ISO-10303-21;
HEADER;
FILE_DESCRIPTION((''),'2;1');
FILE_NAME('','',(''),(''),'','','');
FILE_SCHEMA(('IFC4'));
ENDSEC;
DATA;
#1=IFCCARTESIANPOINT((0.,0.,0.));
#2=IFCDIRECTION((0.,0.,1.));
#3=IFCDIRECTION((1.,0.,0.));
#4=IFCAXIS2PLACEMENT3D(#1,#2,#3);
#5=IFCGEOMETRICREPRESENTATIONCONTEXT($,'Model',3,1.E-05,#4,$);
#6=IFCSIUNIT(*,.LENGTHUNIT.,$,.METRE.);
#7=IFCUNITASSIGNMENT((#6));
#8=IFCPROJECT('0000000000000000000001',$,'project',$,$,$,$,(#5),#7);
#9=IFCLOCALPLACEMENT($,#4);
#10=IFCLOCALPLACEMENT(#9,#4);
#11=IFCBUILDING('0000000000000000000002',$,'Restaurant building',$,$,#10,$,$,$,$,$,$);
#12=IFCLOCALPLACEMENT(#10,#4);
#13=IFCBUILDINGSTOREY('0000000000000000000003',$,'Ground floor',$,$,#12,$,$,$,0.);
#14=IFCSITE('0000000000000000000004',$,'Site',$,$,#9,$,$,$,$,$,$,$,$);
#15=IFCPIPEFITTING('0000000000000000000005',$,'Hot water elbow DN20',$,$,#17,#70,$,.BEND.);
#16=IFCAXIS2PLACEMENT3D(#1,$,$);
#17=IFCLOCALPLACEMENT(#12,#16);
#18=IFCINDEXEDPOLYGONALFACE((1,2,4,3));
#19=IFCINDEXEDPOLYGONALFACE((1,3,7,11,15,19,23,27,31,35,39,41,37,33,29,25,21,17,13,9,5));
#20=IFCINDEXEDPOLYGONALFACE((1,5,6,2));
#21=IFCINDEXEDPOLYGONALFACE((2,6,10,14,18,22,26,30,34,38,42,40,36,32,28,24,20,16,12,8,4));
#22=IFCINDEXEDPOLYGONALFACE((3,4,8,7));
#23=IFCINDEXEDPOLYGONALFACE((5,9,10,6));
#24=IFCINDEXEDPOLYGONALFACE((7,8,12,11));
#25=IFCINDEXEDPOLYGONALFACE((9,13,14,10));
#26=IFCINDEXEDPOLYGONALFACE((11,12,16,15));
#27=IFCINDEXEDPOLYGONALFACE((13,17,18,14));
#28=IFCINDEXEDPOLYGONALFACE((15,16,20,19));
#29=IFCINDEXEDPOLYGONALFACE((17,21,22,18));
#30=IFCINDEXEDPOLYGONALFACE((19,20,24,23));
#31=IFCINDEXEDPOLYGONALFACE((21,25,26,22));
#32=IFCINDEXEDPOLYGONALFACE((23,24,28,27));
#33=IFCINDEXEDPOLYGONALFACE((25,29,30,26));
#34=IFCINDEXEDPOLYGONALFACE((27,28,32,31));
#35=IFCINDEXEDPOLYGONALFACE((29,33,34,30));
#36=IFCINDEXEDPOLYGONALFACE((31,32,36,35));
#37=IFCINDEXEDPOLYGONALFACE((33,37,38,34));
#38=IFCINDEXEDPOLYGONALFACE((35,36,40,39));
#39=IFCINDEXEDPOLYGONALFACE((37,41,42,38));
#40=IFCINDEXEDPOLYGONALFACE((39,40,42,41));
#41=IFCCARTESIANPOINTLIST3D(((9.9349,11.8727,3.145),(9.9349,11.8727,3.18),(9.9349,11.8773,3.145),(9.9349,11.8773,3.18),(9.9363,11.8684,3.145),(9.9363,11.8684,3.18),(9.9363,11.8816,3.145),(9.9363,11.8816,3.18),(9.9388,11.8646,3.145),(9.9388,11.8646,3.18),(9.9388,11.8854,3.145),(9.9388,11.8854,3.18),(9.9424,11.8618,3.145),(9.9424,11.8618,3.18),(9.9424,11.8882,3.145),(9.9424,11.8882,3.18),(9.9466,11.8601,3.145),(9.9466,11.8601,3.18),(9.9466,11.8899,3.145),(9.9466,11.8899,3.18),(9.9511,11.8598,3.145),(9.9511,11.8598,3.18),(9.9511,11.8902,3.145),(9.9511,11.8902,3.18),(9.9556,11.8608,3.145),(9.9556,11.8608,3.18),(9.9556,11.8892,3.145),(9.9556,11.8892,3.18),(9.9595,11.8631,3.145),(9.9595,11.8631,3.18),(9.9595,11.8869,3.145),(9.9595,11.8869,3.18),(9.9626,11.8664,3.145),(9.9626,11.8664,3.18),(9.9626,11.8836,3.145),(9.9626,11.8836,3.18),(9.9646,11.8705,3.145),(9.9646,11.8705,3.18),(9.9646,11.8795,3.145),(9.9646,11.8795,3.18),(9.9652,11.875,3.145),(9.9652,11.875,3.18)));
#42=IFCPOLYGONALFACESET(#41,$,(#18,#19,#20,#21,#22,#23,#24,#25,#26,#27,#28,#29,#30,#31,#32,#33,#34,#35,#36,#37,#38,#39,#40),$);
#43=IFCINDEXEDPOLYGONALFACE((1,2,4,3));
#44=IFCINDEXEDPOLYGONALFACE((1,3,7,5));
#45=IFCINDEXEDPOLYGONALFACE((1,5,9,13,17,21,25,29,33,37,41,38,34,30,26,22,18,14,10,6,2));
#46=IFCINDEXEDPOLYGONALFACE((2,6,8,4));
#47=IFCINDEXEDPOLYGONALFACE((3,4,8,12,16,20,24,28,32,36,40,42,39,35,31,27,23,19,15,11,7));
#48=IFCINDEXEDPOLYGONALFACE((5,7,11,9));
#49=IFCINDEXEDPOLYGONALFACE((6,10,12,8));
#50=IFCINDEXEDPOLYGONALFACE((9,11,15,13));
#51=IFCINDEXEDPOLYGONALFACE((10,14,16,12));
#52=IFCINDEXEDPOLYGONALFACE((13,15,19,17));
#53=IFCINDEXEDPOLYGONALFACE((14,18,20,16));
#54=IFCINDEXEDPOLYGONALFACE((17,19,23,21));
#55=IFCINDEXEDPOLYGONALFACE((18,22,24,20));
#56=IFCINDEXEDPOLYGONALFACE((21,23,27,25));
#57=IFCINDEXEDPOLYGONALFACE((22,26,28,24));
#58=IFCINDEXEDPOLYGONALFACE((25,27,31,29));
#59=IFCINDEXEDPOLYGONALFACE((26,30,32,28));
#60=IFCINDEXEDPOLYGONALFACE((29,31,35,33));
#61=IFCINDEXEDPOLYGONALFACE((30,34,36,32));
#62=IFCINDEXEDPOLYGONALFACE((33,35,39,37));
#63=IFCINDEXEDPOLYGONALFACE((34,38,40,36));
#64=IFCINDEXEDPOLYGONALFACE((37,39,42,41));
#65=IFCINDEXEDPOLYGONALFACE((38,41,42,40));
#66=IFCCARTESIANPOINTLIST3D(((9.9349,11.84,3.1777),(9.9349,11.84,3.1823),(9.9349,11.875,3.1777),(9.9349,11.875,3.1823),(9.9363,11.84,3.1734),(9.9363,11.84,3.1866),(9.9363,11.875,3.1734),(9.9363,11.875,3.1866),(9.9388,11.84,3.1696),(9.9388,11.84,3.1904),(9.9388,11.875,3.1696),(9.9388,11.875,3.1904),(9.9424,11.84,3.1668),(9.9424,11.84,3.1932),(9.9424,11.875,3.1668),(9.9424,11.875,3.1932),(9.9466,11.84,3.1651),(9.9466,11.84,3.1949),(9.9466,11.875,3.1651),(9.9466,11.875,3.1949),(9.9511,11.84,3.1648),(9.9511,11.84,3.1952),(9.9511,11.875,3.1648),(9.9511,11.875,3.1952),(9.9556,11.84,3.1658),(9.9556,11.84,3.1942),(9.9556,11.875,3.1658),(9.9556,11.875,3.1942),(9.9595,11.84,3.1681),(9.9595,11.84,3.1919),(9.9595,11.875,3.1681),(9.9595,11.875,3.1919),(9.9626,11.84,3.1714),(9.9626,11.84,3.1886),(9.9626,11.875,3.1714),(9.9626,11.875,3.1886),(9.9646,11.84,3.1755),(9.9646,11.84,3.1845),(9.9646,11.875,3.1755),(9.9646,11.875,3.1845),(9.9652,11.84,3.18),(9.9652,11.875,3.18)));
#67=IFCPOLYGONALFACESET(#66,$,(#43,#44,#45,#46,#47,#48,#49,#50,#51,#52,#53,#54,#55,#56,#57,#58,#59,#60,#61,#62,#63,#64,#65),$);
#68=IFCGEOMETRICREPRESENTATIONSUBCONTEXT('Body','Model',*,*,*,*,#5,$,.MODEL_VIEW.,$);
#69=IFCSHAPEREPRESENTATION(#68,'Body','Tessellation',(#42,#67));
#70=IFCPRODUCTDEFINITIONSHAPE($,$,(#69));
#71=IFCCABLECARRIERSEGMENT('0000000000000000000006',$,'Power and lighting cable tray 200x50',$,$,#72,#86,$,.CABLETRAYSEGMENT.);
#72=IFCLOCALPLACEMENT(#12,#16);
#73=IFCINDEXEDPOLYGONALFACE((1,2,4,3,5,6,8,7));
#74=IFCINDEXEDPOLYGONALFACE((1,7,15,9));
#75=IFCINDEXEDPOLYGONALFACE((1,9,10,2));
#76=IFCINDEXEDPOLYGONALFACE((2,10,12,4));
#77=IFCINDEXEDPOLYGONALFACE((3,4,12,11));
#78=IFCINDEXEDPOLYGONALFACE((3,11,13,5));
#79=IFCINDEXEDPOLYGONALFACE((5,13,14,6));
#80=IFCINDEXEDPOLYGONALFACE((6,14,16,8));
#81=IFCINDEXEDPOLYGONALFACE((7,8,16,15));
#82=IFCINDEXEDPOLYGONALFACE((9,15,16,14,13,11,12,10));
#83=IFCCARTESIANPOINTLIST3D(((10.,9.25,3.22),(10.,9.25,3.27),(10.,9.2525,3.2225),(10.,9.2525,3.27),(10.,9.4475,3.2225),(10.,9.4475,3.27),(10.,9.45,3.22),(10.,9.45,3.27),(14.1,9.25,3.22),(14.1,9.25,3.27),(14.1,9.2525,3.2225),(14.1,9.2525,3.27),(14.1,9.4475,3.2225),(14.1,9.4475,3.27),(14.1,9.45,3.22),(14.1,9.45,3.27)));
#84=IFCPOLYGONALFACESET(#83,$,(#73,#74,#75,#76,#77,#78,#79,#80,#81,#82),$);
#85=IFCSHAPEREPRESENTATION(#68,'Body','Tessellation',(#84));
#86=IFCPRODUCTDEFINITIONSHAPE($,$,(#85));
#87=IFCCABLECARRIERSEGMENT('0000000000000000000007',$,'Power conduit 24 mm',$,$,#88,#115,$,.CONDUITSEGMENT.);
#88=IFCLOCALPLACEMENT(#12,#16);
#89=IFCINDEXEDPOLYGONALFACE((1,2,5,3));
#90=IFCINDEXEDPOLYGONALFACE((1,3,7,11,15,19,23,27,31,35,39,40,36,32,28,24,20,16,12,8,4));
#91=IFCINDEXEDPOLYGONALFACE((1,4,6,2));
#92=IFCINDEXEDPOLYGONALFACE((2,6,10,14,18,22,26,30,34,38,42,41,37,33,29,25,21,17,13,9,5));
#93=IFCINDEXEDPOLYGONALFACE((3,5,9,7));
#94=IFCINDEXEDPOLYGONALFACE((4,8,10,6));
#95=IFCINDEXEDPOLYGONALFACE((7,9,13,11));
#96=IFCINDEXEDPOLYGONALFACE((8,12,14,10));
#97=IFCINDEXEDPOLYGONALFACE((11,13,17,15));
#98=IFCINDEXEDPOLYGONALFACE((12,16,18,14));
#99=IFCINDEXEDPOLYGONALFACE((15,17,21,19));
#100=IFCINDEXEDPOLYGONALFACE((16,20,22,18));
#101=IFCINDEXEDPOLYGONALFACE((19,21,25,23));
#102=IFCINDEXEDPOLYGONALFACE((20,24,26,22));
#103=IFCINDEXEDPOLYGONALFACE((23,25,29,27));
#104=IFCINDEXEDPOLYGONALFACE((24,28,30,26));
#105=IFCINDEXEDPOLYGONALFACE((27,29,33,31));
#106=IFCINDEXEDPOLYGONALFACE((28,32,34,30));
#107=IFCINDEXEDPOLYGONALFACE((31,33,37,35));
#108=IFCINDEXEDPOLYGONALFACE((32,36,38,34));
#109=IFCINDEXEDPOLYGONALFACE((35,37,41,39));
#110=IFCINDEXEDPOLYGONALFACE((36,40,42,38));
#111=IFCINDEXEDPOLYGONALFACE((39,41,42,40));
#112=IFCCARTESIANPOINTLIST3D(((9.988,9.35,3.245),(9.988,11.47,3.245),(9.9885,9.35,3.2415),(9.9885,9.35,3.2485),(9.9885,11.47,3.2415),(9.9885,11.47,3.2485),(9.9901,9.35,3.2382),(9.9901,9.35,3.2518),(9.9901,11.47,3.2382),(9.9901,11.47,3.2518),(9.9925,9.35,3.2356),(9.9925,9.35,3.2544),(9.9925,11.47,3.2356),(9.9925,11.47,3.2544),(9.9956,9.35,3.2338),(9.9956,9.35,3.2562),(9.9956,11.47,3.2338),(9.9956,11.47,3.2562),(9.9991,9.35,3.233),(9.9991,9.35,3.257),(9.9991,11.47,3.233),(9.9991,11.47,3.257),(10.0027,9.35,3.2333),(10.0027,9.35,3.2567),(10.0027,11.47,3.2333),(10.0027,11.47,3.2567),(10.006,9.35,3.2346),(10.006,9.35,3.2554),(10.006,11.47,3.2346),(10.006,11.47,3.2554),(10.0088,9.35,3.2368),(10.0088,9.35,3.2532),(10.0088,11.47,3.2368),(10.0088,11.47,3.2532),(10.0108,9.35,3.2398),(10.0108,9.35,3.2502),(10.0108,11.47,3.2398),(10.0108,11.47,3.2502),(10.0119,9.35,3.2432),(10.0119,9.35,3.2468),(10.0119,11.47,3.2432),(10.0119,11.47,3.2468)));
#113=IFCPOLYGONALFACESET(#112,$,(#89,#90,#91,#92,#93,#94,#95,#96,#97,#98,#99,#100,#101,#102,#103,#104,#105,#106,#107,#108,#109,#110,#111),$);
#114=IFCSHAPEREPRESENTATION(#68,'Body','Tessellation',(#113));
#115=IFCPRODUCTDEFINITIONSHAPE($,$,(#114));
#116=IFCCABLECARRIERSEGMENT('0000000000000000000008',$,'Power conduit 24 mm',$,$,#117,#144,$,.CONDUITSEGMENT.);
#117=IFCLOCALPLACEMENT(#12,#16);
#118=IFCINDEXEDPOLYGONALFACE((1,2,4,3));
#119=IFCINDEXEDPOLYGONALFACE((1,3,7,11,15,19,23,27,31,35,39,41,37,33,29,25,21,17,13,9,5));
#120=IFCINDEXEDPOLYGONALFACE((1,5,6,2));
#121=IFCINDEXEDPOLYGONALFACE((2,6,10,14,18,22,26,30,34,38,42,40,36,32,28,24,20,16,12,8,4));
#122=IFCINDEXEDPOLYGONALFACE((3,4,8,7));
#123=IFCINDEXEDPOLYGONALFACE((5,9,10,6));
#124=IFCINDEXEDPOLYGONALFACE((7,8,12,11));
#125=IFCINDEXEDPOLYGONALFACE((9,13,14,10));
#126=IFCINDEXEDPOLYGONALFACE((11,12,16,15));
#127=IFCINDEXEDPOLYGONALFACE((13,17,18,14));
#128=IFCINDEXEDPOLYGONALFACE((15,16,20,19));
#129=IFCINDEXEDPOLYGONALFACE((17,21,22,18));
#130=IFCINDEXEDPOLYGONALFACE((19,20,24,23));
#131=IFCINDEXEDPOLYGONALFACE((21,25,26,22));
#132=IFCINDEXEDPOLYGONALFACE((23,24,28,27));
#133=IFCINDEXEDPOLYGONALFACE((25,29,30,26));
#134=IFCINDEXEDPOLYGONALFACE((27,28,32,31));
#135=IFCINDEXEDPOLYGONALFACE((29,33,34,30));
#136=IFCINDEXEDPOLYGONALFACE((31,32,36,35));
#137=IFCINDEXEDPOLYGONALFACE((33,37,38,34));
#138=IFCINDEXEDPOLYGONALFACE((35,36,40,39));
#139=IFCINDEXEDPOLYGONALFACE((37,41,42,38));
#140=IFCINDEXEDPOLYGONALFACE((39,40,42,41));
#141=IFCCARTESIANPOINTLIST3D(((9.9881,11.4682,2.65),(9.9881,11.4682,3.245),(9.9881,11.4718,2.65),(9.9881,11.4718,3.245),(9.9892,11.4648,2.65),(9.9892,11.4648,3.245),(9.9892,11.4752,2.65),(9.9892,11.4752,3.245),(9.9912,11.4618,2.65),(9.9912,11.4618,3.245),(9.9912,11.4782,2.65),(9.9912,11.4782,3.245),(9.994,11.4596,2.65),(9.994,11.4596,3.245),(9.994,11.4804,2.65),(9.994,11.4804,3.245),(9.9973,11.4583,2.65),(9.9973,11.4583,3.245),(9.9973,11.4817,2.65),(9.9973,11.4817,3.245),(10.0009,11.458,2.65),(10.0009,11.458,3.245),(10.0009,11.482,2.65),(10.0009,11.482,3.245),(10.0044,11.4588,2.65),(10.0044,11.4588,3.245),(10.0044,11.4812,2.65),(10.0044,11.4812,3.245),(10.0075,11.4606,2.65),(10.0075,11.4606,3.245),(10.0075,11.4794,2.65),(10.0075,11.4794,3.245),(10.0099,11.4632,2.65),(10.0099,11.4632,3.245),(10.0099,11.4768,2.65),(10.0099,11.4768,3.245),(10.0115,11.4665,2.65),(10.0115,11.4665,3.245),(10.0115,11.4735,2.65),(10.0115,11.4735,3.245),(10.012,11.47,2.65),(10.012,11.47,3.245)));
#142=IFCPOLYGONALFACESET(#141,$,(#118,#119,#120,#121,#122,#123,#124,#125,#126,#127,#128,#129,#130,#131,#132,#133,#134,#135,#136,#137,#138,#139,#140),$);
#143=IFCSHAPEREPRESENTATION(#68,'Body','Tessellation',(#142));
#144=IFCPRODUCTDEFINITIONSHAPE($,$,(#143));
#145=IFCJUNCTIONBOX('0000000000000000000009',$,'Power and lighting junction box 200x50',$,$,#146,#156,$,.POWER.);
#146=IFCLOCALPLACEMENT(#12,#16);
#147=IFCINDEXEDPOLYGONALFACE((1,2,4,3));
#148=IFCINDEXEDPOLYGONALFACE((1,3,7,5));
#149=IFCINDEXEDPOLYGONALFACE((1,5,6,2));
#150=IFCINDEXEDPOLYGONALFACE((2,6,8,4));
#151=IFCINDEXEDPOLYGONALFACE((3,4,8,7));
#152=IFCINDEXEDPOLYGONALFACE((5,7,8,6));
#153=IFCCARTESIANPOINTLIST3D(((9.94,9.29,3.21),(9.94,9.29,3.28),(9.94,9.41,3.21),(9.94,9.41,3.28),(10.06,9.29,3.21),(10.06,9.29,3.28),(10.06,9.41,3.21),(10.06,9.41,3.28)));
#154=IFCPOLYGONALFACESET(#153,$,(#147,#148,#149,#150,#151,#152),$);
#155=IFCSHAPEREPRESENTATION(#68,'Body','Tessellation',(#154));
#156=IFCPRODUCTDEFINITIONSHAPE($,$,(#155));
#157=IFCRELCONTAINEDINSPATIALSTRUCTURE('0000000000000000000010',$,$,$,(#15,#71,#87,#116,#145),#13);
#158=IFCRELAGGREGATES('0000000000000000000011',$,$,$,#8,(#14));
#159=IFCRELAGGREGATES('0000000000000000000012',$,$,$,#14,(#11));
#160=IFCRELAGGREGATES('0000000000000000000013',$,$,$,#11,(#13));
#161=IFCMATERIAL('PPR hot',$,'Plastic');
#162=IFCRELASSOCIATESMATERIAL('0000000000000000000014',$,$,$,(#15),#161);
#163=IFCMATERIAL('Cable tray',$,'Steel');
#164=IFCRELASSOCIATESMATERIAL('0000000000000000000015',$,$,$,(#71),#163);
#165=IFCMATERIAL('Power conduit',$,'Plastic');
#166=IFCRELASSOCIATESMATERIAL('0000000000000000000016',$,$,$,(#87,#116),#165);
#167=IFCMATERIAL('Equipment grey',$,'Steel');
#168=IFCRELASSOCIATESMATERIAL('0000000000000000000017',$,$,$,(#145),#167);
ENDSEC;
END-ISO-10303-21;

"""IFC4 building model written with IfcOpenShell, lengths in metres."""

from ifc_helpers import new_model, si_unit, frame, origin_with_axes, origin_2d, place, context, subcontext, project, spatial, polyline, rectangle, circle, outline, extrude, material, element, save


model = new_model("IFC4")

# Units and contexts
model_context = context("Model", 3, precision=1e-05, world=origin_with_axes())
body_context = subcontext(model_context, "Body", "Model", "MODEL_VIEW")
ifc_project = project(units=[si_unit("LENGTHUNIT", "METRE")], contexts=[model_context])

# Site, building, storey
site_placement = place(None, origin_with_axes())
site = spatial("IfcSite", under=ifc_project, at=site_placement, Name="Site")
building_placement = place(site_placement, origin_with_axes())
building = spatial("IfcBuilding", under=site, at=building_placement, Name="Restaurant building")
storey_placement = place(building_placement, origin_with_axes())
storey = spatial("IfcBuildingStorey", under=building, at=storey_placement, Name="Ground floor", Elevation=0.0)

# Shared definitions
ifc_material_1 = material(Name="PPR hot", Category="Plastic")

# Pipe fitting
pipe_fitting_1_placement = place(storey_placement, frame((9.95, 11.875, 3.18)))
element("IfcPipeFitting", 1, at=pipe_fitting_1_placement, inside=storey, material=ifc_material_1, Name="Hot water elbow DN20", PredefinedType="BEND", context=body_context, shape_type="SweptSolid", body=[
    extrude(circle(Radius=0.0152, at=origin_2d()), frame((0.0, 0.0, 0.0), z_axis=(0.0, 0.0, -1.0), x_axis=(1.0, 0.0, 0.0)), (0.0, 0.0, 1.0), 0.035),
    extrude(circle(Radius=0.0152, at=origin_2d()), frame((0.0, 0.0, 0.0), z_axis=(0.0, -1.0, 0.0), x_axis=(1.0, 0.0, 0.0)), (0.0, 0.0, 1.0), 0.035),
])

# Cable carrier segments
ifc_material_2 = material(Name="Cable tray", Category="Steel")
cable_carrier_segment_1_placement = place(storey_placement, frame((10.0, 9.35, 3.245)))
element("IfcCableCarrierSegment", 2, at=cable_carrier_segment_1_placement, inside=storey, material=ifc_material_2, Name="Power and lighting cable tray 200x50", PredefinedType="CABLETRAYSEGMENT", context=body_context, shape_type="SweptSolid", body=[
    extrude(outline(polyline([(-0.1, -0.025), (0.1, -0.025), (0.1, 0.025), (0.0975, 0.025), (0.0975, -0.0225), (-0.0975, -0.0225), (-0.0975, 0.025), (-0.1, 0.025), (-0.1, -0.025)])), frame((0.0, 0.0, 0.0), z_axis=(1.0, 0.0, 0.0), x_axis=(0.0, 1.0, 0.0)), (0.0, 0.0, 1.0), 4.1),
])
ifc_material_3 = material(Name="Power conduit", Category="Plastic")
cable_carrier_segment_2_placement = place(storey_placement, frame((10.0, 9.35, 3.245)))
element("IfcCableCarrierSegment", 3, at=cable_carrier_segment_2_placement, inside=storey, material=ifc_material_3, Name="Power conduit 24 mm", PredefinedType="CONDUITSEGMENT", context=body_context, shape_type="SweptSolid", body=[
    extrude(circle(Radius=0.012, at=origin_2d()), frame((0.0, 0.0, 0.0), z_axis=(0.0, 1.0, 0.0), x_axis=(-1.0, 0.0, 0.0)), (0.0, 0.0, 1.0), 2.12),
])
cable_carrier_segment_3_placement = place(storey_placement, frame((10.0, 11.47, 3.245)))
element("IfcCableCarrierSegment", 4, at=cable_carrier_segment_3_placement, inside=storey, material=ifc_material_3, Name="Power conduit 24 mm", PredefinedType="CONDUITSEGMENT", context=body_context, shape_type="SweptSolid", body=[
    extrude(circle(Radius=0.012, at=origin_2d()), frame((0.0, 0.0, 0.0), z_axis=(0.0, 0.0, -1.0), x_axis=(1.0, 0.0, 0.0)), (0.0, 0.0, 1.0), 0.595),
])

# Junction box
ifc_material_4 = material(Name="Equipment grey", Category="Steel")
junction_box_placement = place(storey_placement, frame((10.0, 9.35, 3.245)))
element("IfcJunctionBox", 5, at=junction_box_placement, inside=storey, material=ifc_material_4, Name="Power and lighting junction box 200x50", PredefinedType="POWER", context=body_context, shape_type="SweptSolid", body=[
    extrude(rectangle(XDim=0.12, YDim=0.12, at=origin_2d()), frame((0.0, 0.0, -0.035)), (0.0, 0.0, 1.0), 0.07),
])

save(model, "model.ifc")
